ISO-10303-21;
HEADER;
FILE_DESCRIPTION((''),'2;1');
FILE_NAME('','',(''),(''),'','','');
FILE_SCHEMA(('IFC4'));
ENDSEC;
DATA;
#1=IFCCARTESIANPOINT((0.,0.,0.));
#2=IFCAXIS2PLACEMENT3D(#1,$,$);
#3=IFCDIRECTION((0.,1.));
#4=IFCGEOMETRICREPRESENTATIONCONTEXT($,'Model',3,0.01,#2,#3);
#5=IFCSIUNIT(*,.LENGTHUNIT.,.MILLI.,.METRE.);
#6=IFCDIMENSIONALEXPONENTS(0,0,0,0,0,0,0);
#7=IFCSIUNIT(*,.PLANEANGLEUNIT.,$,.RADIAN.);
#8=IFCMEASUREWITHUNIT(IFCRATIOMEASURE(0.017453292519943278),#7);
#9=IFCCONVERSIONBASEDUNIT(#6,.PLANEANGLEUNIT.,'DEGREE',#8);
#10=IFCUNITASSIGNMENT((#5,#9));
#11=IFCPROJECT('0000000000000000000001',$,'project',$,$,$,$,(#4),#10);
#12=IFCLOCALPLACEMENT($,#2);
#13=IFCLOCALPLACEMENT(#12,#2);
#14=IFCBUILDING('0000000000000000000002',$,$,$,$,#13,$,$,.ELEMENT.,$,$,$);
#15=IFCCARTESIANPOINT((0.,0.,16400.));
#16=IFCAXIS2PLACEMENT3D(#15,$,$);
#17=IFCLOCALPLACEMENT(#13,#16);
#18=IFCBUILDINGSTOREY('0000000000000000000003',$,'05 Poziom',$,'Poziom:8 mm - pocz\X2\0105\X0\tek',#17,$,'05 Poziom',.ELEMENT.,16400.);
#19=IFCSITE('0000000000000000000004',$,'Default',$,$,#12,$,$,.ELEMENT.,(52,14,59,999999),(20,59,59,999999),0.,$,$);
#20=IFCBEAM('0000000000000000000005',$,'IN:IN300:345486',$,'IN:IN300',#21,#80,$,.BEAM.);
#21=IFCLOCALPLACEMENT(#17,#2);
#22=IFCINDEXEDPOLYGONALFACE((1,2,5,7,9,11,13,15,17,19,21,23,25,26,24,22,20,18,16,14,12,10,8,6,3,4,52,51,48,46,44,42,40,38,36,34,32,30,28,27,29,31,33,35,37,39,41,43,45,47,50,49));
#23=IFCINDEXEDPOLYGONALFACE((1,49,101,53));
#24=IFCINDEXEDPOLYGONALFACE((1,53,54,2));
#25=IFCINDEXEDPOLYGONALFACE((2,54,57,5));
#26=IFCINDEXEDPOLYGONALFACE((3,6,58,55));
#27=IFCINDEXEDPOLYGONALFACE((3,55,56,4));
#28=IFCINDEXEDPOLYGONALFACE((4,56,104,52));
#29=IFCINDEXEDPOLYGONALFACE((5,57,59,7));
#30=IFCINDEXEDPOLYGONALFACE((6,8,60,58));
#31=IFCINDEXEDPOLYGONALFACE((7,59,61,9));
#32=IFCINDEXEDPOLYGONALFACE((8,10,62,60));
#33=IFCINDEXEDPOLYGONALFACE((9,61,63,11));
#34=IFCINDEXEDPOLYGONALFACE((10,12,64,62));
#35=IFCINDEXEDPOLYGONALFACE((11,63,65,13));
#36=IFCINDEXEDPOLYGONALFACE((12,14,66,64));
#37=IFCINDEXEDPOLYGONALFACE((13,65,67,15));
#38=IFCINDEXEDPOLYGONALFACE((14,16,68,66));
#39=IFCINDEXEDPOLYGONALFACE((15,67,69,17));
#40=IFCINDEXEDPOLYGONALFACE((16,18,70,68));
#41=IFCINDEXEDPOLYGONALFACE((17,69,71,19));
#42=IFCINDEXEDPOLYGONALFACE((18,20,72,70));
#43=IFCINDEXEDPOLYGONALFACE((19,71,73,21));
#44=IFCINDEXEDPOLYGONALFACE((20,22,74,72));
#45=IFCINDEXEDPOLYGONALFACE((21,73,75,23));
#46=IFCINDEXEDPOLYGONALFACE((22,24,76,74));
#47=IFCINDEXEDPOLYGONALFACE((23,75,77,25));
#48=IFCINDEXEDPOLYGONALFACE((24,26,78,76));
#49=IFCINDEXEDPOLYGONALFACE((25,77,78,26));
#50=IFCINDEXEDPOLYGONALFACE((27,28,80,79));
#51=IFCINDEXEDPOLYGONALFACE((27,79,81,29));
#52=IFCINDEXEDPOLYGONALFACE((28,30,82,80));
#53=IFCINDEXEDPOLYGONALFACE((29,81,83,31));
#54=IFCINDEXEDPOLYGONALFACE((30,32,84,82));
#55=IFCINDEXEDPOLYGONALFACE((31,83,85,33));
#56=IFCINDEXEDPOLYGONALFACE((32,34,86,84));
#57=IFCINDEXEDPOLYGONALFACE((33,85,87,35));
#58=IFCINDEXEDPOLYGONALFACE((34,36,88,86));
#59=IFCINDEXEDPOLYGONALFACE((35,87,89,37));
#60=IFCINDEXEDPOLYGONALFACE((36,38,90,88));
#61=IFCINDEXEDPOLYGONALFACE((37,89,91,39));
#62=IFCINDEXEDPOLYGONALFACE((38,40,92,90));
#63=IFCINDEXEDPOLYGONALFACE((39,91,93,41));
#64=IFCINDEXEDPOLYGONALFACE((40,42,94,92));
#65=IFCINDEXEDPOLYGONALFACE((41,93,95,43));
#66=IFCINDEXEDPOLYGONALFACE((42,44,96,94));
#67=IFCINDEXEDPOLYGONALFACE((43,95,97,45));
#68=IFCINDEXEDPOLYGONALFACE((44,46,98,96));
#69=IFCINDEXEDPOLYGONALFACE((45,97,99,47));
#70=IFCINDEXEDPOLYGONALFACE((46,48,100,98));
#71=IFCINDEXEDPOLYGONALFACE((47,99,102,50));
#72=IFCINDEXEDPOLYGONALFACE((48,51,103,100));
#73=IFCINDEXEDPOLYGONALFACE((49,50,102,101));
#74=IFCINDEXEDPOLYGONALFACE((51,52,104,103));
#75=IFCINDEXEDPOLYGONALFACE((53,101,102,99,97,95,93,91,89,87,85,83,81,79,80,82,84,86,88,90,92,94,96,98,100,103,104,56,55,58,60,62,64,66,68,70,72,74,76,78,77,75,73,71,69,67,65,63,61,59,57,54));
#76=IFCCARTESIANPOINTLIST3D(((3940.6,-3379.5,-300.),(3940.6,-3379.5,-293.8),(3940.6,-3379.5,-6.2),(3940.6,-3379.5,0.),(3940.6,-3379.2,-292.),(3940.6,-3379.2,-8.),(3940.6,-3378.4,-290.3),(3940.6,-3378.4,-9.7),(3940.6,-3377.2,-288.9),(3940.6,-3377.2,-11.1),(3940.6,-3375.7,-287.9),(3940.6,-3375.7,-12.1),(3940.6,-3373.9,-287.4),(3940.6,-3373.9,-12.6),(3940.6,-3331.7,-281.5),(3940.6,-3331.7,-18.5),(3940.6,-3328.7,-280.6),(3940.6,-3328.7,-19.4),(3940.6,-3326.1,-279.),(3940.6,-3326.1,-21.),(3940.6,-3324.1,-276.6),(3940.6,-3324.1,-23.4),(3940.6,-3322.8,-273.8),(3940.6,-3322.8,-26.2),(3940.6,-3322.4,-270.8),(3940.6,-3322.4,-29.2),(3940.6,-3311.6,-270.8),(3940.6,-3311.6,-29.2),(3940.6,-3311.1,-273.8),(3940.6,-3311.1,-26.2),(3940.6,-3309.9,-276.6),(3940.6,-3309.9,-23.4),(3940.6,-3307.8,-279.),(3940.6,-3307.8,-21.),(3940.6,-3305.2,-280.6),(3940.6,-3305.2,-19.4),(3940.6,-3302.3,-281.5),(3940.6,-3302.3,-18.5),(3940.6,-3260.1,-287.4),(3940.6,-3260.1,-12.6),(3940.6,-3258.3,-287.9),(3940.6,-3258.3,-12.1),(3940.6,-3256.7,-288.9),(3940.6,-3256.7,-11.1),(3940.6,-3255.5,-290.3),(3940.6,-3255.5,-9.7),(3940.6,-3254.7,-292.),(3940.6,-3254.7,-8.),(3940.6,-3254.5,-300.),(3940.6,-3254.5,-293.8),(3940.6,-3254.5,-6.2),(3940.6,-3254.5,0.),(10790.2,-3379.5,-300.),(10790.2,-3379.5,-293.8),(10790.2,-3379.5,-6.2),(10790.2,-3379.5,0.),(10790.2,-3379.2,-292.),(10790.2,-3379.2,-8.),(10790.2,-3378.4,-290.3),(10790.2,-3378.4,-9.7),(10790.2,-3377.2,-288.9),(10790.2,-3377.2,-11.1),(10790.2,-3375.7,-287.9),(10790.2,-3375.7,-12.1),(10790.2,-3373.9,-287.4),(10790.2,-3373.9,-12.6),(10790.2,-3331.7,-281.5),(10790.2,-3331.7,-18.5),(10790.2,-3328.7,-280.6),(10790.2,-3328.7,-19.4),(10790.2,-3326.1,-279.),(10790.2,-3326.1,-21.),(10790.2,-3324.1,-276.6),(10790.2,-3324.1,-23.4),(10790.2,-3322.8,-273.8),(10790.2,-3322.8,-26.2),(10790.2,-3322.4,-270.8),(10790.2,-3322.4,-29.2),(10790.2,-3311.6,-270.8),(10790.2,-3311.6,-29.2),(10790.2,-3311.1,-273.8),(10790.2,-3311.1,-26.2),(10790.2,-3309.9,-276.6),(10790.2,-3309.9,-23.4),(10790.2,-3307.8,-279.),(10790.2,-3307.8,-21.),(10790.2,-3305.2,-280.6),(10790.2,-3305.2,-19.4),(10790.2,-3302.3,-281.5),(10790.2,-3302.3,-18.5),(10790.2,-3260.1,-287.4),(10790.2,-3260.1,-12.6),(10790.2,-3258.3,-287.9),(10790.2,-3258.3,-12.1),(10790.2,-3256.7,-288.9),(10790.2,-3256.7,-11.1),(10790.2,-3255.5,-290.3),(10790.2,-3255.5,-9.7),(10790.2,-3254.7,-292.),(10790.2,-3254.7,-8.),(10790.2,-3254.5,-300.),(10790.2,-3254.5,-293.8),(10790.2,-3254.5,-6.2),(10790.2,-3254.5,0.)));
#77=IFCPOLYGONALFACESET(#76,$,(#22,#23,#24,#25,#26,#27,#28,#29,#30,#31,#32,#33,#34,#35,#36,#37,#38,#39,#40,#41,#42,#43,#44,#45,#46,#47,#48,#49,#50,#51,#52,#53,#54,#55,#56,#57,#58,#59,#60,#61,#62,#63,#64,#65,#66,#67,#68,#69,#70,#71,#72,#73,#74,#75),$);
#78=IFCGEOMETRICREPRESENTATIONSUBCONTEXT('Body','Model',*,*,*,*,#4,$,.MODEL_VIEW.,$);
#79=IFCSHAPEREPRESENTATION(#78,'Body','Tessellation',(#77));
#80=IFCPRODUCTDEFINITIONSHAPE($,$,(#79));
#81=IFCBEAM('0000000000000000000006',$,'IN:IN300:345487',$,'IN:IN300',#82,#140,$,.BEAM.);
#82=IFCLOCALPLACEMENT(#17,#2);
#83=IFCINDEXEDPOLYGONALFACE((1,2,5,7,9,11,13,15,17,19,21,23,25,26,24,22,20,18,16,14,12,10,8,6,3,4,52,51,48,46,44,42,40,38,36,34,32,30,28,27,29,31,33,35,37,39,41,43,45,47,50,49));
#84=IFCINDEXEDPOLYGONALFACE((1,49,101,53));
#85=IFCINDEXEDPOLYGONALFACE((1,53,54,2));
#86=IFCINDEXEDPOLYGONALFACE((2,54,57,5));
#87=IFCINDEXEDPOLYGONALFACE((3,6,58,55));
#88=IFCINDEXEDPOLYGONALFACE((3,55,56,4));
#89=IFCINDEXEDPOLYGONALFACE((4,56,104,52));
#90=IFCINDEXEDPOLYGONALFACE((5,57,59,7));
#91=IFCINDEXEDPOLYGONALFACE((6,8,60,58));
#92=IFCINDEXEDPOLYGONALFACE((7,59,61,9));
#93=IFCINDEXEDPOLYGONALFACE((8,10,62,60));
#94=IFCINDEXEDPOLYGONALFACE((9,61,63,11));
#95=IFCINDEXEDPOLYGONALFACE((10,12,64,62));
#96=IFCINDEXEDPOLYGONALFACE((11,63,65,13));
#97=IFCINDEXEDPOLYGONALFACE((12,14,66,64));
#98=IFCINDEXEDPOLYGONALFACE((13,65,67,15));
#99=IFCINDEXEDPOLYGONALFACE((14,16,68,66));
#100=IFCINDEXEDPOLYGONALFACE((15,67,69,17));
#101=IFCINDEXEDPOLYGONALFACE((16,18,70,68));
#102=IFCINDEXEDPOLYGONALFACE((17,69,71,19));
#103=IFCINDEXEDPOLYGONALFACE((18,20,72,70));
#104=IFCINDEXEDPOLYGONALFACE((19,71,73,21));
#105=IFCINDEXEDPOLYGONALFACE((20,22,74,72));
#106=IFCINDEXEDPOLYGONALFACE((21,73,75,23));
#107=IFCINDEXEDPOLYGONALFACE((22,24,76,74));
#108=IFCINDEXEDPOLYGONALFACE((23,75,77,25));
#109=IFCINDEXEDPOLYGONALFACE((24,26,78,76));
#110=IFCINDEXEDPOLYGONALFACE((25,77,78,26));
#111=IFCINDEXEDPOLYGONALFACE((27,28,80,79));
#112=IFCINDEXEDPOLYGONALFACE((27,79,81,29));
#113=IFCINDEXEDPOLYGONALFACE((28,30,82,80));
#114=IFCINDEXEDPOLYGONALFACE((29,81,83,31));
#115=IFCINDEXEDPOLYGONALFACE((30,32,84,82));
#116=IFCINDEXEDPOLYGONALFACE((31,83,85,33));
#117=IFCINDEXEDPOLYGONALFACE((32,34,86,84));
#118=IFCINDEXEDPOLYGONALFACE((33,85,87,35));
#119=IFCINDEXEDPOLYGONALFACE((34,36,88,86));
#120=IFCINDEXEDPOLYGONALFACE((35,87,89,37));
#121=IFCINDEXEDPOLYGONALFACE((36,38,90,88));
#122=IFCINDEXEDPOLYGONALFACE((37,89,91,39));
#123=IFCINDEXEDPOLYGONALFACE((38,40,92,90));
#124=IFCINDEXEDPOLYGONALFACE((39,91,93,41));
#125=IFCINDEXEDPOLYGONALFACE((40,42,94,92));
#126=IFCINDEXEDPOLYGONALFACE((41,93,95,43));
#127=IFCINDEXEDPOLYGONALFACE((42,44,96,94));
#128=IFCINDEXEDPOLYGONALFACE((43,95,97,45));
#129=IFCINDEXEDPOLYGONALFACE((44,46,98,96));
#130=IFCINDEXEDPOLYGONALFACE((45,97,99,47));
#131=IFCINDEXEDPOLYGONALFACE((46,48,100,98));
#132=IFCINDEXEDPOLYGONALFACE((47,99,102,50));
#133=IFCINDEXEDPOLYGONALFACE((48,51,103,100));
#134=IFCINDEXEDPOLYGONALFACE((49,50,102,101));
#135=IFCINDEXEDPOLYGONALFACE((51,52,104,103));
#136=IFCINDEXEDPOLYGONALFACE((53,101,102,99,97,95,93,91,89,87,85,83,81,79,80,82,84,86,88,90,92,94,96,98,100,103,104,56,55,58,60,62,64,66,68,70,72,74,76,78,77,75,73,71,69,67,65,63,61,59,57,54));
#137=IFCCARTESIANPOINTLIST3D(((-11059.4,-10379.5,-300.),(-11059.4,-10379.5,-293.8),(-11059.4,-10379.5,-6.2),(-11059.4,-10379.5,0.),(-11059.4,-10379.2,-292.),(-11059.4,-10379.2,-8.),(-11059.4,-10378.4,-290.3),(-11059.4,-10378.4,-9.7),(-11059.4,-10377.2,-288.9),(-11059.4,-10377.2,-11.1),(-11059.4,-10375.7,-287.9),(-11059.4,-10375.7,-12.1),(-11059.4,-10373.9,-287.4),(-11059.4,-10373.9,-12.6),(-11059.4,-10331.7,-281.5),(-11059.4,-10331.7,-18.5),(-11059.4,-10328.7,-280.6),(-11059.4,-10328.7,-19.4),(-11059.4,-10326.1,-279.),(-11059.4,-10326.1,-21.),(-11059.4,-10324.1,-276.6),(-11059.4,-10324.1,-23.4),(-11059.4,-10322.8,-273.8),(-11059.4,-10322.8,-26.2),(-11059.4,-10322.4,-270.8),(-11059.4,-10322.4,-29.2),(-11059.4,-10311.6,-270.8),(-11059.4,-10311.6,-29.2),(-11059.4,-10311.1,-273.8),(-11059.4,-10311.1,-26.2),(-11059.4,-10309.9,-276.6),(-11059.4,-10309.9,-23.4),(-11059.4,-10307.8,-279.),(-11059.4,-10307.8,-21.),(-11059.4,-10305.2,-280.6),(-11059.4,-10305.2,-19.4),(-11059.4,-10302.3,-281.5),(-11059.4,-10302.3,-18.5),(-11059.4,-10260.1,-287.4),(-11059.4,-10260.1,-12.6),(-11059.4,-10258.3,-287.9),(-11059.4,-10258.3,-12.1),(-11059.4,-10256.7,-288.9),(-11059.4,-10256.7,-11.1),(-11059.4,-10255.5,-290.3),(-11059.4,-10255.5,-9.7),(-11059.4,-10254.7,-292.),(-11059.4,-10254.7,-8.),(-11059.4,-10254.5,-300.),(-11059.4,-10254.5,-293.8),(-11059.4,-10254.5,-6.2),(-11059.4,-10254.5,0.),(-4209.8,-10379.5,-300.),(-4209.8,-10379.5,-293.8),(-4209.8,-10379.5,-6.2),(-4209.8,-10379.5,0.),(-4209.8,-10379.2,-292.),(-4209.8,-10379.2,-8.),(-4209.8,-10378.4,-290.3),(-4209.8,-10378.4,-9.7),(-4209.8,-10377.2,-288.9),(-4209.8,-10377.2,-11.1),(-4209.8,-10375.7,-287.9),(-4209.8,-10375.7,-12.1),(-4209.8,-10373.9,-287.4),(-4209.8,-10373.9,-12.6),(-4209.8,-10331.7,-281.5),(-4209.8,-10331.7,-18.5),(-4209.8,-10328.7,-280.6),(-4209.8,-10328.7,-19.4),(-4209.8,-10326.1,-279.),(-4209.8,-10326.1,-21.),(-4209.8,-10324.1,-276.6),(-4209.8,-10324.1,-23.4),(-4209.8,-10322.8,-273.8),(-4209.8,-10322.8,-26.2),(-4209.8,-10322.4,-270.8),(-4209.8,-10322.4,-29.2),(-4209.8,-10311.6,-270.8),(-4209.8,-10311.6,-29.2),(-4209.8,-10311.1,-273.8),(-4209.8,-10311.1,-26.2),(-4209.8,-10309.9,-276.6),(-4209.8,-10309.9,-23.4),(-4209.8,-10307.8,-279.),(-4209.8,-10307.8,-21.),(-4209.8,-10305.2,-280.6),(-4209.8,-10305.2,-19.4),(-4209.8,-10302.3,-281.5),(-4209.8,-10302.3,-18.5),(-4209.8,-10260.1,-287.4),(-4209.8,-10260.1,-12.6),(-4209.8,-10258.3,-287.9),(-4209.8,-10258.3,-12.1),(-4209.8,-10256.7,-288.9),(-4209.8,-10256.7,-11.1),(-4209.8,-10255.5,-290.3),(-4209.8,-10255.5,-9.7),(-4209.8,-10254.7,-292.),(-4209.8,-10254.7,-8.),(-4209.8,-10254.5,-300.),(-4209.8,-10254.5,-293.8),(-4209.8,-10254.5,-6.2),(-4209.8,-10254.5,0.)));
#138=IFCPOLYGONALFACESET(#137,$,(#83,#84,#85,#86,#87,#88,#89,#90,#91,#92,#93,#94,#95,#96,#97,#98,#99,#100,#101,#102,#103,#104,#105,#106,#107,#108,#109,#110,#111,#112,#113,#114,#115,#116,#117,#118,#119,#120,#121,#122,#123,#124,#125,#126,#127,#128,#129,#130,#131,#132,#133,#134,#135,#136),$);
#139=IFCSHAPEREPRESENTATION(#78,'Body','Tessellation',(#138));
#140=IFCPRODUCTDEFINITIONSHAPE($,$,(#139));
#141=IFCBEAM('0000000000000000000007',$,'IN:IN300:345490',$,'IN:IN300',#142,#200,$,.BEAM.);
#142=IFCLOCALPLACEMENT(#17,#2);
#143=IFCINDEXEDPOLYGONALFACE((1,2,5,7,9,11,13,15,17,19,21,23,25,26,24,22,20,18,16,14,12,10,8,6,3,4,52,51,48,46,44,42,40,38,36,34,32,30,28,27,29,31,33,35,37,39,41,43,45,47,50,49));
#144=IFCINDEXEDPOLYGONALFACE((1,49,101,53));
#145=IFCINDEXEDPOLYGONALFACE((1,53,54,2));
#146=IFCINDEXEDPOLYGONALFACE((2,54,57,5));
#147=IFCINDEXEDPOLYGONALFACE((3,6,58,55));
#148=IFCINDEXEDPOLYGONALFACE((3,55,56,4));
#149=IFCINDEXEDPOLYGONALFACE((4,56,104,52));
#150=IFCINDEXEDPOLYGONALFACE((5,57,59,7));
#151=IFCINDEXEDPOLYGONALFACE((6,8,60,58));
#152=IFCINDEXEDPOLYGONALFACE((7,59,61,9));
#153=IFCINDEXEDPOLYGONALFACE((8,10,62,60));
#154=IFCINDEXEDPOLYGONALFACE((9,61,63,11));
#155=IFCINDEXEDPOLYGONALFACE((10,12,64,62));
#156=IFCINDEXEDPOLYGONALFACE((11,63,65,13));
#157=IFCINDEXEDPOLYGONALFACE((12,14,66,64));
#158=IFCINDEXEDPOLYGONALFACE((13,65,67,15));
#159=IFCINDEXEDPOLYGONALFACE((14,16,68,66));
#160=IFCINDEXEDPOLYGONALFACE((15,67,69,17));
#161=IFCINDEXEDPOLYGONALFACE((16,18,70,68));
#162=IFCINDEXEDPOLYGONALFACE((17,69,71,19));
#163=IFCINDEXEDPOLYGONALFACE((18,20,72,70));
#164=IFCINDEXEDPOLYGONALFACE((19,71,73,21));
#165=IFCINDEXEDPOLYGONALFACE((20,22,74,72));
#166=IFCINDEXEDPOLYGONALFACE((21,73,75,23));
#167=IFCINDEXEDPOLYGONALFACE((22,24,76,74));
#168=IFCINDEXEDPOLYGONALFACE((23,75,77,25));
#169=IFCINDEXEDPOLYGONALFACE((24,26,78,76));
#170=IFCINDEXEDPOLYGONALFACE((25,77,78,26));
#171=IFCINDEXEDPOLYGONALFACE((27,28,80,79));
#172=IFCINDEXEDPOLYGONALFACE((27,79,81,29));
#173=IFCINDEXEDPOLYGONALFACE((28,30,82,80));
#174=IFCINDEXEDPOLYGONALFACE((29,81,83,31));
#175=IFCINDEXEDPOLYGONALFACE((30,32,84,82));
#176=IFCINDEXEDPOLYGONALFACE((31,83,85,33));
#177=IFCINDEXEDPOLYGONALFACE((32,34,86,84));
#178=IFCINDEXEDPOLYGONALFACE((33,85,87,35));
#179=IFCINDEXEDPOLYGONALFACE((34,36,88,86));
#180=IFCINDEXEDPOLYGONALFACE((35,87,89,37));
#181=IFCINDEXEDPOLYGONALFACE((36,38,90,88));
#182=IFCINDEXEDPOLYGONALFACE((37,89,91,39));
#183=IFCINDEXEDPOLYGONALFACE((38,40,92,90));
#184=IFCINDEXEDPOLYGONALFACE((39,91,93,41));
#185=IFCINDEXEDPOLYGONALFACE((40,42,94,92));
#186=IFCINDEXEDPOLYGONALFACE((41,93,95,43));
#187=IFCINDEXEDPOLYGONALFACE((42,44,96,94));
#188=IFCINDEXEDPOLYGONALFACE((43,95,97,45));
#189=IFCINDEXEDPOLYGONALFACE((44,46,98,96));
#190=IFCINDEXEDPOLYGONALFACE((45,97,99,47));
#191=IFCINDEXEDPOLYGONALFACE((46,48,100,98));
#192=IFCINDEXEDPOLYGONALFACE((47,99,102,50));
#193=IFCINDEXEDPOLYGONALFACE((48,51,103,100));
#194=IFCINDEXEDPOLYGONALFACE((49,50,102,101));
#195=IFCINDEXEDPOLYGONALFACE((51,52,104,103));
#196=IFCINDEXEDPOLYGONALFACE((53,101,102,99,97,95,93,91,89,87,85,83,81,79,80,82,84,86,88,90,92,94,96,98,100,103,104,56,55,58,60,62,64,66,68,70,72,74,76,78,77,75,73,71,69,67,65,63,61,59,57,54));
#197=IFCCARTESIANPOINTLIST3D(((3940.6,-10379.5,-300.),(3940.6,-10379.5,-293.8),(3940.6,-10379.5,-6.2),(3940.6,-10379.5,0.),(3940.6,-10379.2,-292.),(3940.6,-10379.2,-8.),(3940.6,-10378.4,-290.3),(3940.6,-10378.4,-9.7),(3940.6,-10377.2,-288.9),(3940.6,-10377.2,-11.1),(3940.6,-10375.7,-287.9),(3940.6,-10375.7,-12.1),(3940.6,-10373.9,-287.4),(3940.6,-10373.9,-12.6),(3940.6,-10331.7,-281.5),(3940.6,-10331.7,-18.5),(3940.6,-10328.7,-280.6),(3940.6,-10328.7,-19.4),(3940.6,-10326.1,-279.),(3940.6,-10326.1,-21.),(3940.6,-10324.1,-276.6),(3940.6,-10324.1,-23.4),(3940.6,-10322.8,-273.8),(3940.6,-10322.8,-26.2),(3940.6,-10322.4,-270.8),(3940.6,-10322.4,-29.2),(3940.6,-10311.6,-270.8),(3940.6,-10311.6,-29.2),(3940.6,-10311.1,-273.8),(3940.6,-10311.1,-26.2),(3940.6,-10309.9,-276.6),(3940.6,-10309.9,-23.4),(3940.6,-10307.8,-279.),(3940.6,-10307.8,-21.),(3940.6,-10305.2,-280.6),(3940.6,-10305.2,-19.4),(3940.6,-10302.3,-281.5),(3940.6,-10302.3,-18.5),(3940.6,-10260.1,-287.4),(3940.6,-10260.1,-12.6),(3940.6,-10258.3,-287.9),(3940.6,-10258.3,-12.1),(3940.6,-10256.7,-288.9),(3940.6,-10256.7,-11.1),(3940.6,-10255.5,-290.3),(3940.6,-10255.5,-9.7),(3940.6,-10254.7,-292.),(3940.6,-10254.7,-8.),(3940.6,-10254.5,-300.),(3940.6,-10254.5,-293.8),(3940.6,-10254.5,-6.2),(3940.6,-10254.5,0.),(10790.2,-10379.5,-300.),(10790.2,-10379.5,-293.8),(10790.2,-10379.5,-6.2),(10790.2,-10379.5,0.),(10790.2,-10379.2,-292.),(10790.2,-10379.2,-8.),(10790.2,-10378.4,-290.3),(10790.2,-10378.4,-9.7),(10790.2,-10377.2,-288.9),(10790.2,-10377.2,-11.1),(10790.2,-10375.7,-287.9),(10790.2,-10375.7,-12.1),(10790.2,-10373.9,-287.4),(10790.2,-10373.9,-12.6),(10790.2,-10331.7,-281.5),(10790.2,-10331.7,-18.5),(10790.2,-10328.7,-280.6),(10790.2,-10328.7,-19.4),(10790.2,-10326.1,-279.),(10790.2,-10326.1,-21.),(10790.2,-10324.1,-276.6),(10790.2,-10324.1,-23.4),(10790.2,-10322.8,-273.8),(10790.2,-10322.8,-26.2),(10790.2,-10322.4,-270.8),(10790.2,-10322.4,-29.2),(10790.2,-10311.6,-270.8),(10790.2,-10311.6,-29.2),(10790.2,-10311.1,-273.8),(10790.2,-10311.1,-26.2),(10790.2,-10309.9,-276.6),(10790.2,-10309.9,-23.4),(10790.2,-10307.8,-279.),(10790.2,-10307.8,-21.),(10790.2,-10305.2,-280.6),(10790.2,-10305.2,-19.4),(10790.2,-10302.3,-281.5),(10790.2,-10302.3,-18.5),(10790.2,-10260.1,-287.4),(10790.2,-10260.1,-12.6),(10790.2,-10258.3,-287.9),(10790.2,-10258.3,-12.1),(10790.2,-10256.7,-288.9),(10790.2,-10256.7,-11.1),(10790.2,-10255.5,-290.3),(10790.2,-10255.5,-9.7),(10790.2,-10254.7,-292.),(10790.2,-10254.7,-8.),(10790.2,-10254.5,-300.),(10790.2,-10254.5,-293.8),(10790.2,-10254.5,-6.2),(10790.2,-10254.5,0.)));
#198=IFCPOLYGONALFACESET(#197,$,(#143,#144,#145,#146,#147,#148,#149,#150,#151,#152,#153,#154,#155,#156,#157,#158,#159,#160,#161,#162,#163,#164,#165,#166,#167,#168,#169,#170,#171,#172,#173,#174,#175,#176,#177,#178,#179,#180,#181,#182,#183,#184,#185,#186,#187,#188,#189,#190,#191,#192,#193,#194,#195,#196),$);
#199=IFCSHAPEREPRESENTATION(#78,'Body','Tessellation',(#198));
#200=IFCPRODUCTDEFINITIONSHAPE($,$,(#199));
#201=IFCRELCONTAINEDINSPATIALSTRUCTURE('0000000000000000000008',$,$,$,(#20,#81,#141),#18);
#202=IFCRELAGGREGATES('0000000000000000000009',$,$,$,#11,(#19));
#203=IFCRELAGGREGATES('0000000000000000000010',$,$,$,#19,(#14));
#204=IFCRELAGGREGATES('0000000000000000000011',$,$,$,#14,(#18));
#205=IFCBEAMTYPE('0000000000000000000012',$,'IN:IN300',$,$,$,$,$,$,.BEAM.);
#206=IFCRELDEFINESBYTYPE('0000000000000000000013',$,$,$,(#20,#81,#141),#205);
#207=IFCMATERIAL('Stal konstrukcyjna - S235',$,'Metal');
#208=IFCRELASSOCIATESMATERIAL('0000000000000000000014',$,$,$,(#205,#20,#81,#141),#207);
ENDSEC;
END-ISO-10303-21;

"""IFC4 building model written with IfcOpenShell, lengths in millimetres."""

from ifc_helpers import new_model, entity, si_unit, converted_unit, direction, frame, origin, place, context, subcontext, project, spatial, line, arc, indexed_curve, outline, extrude, source, transform, mapped, material, type_object, type_shapes, element, save


model = new_model("IFC4")

# Units and contexts
model_context = context("Model", 3, precision=0.01, world=origin(), true_north=direction((0.0, 1.0)))
body_context = subcontext(model_context, "Body", "Model", "MODEL_VIEW")
ifc_project = project(units=[si_unit("LENGTHUNIT", "METRE", prefix="MILLI"), converted_unit("PLANEANGLEUNIT", "DEGREE", entity("IfcRatioMeasure", 0.017453292519943278), si_unit("PLANEANGLEUNIT", "RADIAN"), dimensions=[0, 0, 0, 0, 0, 0, 0])], contexts=[model_context])

# Site, building, storey
site_placement = place(None, origin())
site = spatial("IfcSite", under=ifc_project, at=site_placement, Name="Default", CompositionType="ELEMENT", RefLatitude=(52, 14, 59, 999999), RefLongitude=(20, 59, 59, 999999), RefElevation=0.0)
building_placement = place(site_placement, origin())
building = spatial("IfcBuilding", under=site, at=building_placement, CompositionType="ELEMENT")
storey_placement = place(building_placement, frame((0.0, 0.0, 16400.0)))
storey = spatial("IfcBuildingStorey", under=building, at=storey_placement, Name="05 Poziom", ObjectType="Poziom:8 mm - początek", LongName="05 Poziom", CompositionType="ELEMENT", Elevation=16400.0)

# Shared definitions
ifc_material = material(Name="Stal konstrukcyjna - S235", Category="Metal")

# Beams
beam_type_1 = type_object("IfcBeamType", Name="IN:IN300", PredefinedType="BEAM", material=ifc_material)
shared_shape_1 = source(origin(), body_context, "Body", "SweptSolid", [
    extrude(outline(indexed_curve([(143.8, -62.5), (150.0, -62.5), (150.0, 62.5), (143.8, 62.5), (139.6, 60.9), (137.4, 56.9), (131.5, 14.7), (127.9, 8.1), (120.8, 5.4), (-120.8, 5.4), (-127.9, 8.1), (-131.5, 14.7), (-137.4, 56.9), (-139.6, 60.9), (-143.8, 62.5), (-150.0, 62.5), (-150.0, -62.5), (-143.8, -62.5), (-139.6, -60.9), (-137.4, -56.9), (-131.5, -14.7), (-127.9, -8.1), (-120.8, -5.4), (120.8, -5.4), (127.9, -8.1), (131.5, -14.7), (137.4, -56.9), (139.6, -60.9)], segments=[line(1, 2, 3, 4), arc(4, 5, 6), line(6, 7), arc(7, 8, 9), line(9, 10), arc(10, 11, 12), line(12, 13), arc(13, 14, 15), line(15, 16, 17, 18), arc(18, 19, 20), line(20, 21), arc(21, 22, 23), line(23, 24), arc(24, 25, 26), line(26, 27), arc(27, 28, 1)], self_intersect=False)), frame((-3424.8, 0.0, 0.0), z_axis=(1.0, 0.0, 0.0), x_axis=(0.0, 0.0, -1.0)), (0.0, 0.0, 1.0), 6849.6),
])
type_shapes(beam_type_1, [shared_shape_1])
for number, where, name in (
    (1, (7365.4, -3317.0, -150.0), "IN:IN300:345486"),
    (2, (-7634.6, -10317.0, -150.0), "IN:IN300:345487"),
    (3, (7365.4, -10317.0, -150.0), "IN:IN300:345490"),
):
    element("IfcBeam", number, at=place(storey_placement, frame(where)), inside=storey, type_object=beam_type_1, material=ifc_material, Name=name, ObjectType="IN:IN300", PredefinedType="BEAM", context=body_context, shape_type="MappedRepresentation", body=[
        mapped(shared_shape_1, transform((0.0, 0.0, 0.0), scale=1.0)),
    ])

save(model, "model.ifc")
